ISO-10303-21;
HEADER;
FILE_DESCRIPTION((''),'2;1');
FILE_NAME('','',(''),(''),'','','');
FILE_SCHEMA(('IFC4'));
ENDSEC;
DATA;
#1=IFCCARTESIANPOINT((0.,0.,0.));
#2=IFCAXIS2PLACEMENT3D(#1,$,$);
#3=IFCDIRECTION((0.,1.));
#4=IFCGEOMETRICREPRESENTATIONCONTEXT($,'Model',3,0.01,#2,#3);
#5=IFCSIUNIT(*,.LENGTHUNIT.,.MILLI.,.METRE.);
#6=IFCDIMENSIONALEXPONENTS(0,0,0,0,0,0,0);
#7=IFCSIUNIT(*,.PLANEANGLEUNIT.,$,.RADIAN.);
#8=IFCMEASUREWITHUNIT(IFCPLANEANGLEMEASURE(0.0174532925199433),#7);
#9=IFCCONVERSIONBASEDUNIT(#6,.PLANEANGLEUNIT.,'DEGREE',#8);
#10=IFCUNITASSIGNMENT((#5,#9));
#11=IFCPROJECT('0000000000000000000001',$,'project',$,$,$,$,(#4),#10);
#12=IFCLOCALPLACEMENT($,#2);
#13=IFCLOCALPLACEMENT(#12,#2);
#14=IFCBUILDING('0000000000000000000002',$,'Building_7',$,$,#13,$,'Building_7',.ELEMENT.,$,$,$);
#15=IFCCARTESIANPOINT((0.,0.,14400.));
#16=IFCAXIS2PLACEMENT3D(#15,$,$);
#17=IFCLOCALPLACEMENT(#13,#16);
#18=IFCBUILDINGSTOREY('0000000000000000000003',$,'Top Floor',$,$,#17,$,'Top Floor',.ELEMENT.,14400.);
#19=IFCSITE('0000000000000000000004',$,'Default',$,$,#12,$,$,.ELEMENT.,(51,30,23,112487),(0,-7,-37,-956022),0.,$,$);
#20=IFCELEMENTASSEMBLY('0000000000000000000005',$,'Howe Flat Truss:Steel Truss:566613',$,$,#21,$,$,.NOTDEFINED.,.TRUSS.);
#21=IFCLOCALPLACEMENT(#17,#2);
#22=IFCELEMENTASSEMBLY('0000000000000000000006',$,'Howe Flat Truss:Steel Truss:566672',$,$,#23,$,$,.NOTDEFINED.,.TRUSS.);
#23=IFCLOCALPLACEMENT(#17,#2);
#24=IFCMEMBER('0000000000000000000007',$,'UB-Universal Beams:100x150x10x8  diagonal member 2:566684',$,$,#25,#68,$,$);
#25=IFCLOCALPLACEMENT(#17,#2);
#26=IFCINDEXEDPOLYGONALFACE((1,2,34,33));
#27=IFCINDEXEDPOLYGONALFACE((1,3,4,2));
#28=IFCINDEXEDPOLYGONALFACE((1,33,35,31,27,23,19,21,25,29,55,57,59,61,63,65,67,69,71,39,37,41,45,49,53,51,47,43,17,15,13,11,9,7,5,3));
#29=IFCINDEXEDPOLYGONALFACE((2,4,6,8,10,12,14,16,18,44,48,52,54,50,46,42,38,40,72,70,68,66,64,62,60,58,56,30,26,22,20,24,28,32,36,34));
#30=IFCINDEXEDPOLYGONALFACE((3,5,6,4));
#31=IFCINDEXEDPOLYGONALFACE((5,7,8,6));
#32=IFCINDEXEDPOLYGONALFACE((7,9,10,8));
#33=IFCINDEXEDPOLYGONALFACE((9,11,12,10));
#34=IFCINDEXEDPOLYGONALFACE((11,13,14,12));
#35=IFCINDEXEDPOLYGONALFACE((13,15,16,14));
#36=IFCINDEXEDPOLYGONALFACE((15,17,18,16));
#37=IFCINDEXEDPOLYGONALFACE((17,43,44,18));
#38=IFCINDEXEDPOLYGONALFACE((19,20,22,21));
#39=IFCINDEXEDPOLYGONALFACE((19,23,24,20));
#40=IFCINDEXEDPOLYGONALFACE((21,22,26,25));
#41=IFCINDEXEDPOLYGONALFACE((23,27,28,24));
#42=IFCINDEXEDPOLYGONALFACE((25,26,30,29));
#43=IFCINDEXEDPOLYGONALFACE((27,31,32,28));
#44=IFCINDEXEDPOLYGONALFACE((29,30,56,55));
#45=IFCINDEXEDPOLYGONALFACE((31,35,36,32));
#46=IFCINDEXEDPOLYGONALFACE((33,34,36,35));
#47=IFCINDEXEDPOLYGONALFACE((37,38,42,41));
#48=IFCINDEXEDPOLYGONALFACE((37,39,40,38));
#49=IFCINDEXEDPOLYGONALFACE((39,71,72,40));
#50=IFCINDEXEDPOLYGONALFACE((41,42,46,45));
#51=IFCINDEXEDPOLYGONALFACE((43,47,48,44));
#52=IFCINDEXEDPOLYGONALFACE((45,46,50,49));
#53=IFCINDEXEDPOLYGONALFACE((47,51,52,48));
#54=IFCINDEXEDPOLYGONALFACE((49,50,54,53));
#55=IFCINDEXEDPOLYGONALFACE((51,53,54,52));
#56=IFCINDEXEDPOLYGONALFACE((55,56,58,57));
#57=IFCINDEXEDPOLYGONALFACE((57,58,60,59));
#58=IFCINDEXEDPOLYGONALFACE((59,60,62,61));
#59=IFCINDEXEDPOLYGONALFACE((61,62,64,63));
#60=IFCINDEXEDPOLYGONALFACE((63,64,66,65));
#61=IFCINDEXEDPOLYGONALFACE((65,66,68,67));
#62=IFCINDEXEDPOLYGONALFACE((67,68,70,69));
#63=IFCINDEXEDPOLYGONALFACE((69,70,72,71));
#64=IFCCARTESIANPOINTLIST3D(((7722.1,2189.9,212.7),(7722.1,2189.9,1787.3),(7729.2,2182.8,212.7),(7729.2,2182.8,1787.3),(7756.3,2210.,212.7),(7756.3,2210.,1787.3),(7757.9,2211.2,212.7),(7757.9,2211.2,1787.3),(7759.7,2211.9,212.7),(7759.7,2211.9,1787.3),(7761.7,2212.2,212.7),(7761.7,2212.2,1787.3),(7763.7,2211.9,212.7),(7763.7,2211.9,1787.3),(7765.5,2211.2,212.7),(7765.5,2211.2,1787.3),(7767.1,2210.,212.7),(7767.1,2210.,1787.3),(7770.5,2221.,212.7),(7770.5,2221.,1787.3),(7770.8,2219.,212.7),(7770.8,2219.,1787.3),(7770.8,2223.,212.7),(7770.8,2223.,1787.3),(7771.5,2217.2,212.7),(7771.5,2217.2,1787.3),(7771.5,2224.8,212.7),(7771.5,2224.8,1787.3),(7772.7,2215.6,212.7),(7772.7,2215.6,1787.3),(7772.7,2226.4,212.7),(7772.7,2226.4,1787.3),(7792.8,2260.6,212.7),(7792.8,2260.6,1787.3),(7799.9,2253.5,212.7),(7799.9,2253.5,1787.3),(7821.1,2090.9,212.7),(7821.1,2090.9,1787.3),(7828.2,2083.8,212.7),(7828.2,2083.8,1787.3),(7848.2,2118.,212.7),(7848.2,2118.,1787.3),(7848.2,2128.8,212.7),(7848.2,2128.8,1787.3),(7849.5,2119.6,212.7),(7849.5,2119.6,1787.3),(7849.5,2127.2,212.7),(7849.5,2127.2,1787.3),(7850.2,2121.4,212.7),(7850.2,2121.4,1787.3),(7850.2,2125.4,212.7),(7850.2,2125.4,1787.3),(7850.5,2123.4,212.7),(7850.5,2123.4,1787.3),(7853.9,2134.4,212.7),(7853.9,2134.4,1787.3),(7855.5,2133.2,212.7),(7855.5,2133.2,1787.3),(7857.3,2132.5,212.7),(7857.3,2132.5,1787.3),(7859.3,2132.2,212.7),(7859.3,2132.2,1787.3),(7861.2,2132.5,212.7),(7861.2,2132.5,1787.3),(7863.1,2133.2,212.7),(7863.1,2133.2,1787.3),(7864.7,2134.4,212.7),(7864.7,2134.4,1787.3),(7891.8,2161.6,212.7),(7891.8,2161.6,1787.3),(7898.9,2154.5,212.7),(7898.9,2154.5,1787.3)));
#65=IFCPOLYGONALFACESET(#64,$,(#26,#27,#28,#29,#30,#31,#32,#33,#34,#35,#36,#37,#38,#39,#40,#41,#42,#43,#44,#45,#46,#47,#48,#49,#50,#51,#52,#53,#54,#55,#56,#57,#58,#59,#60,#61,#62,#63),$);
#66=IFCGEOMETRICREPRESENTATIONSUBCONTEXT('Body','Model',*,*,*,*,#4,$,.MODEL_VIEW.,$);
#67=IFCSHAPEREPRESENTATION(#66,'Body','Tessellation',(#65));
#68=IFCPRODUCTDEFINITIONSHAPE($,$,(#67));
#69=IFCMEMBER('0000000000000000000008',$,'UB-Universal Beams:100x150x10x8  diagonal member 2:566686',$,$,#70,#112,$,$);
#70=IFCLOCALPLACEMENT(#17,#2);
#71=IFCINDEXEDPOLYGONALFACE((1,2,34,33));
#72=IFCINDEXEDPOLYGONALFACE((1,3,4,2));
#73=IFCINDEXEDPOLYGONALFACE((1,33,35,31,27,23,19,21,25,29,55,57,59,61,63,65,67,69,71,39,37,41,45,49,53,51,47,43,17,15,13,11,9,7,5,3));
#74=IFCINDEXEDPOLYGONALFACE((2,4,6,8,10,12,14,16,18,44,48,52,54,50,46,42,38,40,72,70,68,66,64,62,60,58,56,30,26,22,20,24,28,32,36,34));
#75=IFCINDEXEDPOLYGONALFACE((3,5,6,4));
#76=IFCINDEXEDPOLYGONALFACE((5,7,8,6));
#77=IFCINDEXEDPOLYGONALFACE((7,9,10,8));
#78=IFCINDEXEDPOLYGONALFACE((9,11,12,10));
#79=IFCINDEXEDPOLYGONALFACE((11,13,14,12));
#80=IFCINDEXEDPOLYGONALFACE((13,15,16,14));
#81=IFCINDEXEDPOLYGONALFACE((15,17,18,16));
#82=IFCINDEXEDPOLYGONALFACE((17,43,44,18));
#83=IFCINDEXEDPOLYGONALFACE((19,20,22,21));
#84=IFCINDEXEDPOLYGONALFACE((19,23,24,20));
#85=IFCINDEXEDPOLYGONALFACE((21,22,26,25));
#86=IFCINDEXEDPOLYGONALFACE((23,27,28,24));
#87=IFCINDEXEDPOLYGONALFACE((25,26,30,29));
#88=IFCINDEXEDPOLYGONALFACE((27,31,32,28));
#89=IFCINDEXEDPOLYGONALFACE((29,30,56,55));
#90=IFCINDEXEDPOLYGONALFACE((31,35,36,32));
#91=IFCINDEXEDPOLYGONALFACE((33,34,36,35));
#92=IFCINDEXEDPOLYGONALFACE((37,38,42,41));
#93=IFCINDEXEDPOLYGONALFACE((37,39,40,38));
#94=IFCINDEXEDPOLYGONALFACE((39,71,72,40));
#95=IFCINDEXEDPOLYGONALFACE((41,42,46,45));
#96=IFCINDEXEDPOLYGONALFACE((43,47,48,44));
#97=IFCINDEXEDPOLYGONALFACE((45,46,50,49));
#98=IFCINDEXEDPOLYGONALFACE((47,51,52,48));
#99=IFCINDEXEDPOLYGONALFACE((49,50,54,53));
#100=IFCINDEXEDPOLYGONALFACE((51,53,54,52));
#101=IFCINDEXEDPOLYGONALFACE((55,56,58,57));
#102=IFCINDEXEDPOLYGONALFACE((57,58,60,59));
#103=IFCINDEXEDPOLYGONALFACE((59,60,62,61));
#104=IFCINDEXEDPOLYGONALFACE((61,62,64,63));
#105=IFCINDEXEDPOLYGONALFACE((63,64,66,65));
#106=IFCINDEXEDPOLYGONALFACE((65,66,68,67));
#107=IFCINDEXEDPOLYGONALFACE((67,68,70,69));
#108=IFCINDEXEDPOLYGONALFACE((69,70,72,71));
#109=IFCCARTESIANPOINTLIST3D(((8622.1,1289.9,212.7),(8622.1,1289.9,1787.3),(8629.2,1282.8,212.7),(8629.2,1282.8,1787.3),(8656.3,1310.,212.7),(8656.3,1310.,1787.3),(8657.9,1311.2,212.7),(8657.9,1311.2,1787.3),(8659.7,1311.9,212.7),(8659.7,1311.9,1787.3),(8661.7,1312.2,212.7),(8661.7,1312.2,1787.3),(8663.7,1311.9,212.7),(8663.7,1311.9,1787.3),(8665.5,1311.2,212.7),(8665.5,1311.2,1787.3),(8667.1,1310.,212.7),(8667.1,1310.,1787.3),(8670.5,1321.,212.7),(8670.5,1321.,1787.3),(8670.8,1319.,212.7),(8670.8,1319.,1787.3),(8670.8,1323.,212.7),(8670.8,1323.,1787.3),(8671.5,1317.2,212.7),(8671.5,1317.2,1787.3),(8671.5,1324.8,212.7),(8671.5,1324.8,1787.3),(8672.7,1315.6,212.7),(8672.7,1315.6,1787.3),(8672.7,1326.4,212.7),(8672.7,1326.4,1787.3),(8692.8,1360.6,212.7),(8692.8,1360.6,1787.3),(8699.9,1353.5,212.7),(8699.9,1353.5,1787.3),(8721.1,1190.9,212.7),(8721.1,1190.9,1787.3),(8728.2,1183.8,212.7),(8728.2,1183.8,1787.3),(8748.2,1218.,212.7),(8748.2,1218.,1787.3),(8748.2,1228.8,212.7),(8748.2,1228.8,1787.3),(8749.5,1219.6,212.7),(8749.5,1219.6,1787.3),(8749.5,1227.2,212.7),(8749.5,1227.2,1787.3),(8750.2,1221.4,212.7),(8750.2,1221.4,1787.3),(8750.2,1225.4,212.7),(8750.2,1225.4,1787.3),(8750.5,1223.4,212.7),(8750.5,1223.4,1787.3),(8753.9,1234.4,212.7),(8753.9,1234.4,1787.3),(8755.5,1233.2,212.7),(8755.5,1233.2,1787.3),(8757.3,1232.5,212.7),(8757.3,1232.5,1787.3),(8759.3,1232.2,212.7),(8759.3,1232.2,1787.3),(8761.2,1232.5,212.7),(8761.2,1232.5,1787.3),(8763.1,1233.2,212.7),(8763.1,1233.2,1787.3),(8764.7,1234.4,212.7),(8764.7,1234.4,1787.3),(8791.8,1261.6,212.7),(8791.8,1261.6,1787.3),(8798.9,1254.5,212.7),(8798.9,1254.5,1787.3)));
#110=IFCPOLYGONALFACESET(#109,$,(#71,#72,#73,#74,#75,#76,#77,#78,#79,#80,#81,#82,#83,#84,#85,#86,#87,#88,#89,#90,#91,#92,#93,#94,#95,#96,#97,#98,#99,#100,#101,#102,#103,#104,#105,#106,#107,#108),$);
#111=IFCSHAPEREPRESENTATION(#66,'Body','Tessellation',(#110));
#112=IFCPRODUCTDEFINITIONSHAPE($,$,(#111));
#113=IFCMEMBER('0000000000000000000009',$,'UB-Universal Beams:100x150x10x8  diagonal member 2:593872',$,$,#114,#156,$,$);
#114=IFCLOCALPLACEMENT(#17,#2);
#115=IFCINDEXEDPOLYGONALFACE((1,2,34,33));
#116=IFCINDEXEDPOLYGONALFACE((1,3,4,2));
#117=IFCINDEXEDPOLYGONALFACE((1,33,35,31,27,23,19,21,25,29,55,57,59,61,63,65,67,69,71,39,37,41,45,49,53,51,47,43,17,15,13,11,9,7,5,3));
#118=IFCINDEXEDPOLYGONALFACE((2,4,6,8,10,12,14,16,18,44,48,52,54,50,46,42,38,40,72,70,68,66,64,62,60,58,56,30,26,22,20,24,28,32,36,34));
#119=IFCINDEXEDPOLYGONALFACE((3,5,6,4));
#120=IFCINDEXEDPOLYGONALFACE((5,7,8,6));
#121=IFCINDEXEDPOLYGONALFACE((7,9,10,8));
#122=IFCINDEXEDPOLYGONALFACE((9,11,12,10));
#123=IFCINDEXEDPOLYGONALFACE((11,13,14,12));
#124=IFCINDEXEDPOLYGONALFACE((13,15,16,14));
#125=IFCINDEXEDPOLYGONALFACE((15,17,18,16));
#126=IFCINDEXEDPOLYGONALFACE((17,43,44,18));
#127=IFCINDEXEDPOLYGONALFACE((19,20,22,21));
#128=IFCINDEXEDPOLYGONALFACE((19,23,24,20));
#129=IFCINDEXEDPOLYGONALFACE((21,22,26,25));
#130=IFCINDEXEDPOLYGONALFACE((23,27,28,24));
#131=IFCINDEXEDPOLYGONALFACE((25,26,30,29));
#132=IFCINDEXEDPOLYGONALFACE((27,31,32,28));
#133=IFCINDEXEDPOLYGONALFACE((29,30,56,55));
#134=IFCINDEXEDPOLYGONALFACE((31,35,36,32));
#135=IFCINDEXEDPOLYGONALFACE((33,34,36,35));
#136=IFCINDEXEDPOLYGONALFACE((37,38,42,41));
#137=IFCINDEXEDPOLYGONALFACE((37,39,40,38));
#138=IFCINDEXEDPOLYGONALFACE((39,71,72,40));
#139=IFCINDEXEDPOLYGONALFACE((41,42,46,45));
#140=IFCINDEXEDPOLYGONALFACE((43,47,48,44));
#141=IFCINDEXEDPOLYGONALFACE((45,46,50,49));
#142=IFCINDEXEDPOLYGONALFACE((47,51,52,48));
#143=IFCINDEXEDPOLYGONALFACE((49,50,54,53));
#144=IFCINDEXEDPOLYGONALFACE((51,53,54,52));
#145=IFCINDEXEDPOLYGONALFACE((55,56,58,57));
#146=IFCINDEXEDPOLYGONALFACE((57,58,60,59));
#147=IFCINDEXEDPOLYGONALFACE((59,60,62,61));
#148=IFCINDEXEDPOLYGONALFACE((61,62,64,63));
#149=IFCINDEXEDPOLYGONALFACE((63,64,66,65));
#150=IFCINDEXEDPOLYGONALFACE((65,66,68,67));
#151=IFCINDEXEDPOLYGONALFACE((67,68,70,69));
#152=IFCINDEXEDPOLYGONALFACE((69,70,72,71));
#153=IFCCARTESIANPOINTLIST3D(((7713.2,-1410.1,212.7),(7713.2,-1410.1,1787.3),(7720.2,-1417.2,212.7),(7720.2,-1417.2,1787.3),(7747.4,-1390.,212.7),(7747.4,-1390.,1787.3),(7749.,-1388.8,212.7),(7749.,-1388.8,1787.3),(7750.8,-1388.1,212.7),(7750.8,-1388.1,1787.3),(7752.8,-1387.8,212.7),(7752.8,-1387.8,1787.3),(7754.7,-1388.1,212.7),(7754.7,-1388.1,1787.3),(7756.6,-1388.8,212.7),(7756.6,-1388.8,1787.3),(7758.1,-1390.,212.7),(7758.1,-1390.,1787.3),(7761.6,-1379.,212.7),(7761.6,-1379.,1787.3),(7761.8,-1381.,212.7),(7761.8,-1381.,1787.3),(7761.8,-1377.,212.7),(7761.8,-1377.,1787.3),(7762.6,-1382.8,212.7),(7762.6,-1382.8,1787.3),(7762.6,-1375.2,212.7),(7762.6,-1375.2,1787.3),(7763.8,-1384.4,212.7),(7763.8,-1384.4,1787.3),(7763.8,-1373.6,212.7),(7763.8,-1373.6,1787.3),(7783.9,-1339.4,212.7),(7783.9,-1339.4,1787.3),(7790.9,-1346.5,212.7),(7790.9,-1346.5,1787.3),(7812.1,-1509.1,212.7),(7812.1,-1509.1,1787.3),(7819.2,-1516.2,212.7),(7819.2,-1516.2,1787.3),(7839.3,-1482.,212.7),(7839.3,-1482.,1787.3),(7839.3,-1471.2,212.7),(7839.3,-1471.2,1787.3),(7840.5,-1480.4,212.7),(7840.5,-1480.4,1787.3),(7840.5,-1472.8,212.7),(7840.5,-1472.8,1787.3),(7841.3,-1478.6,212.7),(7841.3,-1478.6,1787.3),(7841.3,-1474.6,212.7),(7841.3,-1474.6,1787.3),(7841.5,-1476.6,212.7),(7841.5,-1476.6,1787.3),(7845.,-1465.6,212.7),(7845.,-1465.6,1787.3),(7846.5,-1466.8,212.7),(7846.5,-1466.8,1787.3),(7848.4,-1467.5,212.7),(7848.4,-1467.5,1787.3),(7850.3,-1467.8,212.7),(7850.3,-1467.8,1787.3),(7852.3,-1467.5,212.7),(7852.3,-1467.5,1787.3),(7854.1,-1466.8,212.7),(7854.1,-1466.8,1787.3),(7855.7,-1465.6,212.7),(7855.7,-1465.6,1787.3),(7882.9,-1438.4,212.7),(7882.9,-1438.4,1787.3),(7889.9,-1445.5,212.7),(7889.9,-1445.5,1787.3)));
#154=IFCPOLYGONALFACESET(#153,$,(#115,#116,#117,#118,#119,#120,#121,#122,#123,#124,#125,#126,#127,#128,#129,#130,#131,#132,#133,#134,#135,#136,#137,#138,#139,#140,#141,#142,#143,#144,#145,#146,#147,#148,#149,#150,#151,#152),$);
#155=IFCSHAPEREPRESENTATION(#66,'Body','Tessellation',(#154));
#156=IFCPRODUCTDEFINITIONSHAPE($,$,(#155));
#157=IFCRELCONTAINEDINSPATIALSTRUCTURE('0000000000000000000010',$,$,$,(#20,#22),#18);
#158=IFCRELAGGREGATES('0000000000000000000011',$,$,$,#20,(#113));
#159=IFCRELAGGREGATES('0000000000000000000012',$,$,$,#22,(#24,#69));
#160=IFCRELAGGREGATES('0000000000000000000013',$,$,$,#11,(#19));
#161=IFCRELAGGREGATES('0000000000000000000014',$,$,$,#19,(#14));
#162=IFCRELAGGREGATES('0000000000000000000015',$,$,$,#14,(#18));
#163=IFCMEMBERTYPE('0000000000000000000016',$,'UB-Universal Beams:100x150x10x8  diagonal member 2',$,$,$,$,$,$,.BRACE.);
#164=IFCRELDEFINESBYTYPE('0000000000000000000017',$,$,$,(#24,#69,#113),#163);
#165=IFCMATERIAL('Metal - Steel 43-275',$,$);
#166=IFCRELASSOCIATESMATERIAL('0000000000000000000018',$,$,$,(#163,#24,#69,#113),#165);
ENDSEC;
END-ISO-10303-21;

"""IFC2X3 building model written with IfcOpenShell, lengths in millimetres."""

from ifc_helpers import new_model, entity, si_unit, converted_unit, direction, frame, frame_2d, origin, place, context, subcontext, project, spatial, polyline, circle_curve, parameter, trimmed, segment, composite_curve, outline, extrude, source, transform, mapped, material, type_object, type_shapes, element, aggregate, save


model = new_model("IFC2X3")

# Units and contexts
model_context = context("Model", 3, precision=0.01, world=origin(), true_north=direction((0.0, 1.0)))
body_context = subcontext(model_context, "Body", "Model", "MODEL_VIEW")
ifc_project = project(units=[si_unit("LENGTHUNIT", "METRE", prefix="MILLI"), converted_unit("PLANEANGLEUNIT", "DEGREE", entity("IfcPlaneAngleMeasure", 0.0174532925199433), si_unit("PLANEANGLEUNIT", "RADIAN"), dimensions=[0, 0, 0, 0, 0, 0, 0])], contexts=[model_context])

# Site, building, storey
site_placement = place(None, origin())
site = spatial("IfcSite", under=ifc_project, at=site_placement, Name="Default", CompositionType="ELEMENT", RefLatitude=(51, 30, 23, 112487), RefLongitude=(0, -7, -37, -956022), RefElevation=0.0)
building_placement = place(site_placement, origin())
building = spatial("IfcBuilding", under=site, at=building_placement, Name="Building_7", LongName="Building_7", CompositionType="ELEMENT")
storey_placement = place(building_placement, frame((0.0, 0.0, 14400.0)))
storey = spatial("IfcBuildingStorey", under=building, at=storey_placement, Name="Top Floor", LongName="Top Floor", CompositionType="ELEMENT", Elevation=14400.0)

# Shared definitions
ifc_material = material(Name="Metal - Steel 43-275")

# Shared definitions
member_type_1 = type_object("IfcMemberType", Name="UB-Universal Beams:100x150x10x8  diagonal member 2", PredefinedType="BRACE", material=ifc_material)
shared_shape_1 = source(origin(), body_context, "Body", "SweptSolid", [
    extrude(outline(composite_curve([segment(polyline([(-50.0, -65.0), (-50.0, -75.0)]), True, "CONTINUOUS"), segment(polyline([(-50.0, -75.0), (50.0, -75.0)]), True, "CONTINUOUS"), segment(polyline([(50.0, -75.0), (50.0, -65.0)]), True, "CONTINUOUS"), segment(polyline([(50.0, -65.0), (11.6, -65.0)]), True, "CONTINUOUS"), segment(trimmed(circle_curve(frame_2d((11.6, -57.4), x_axis=(1.0, 0.0)), 7.6), [parameter(180.0)], [parameter(270.0)], True, "PARAMETER"), False, "CONTINUOUS"), segment(polyline([(4.0, -57.4), (4.0, 57.4)]), True, "CONTINUOUS"), segment(trimmed(circle_curve(frame_2d((11.6, 57.4), x_axis=(1.0, 0.0)), 7.6), [parameter(90.0)], [parameter(180.0)], True, "PARAMETER"), False, "CONTINUOUS"), segment(polyline([(11.6, 65.0), (50.0, 65.0)]), True, "CONTINUOUS"), segment(polyline([(50.0, 65.0), (50.0, 75.0)]), True, "CONTINUOUS"), segment(polyline([(50.0, 75.0), (-50.0, 75.0)]), True, "CONTINUOUS"), segment(polyline([(-50.0, 75.0), (-50.0, 65.0)]), True, "CONTINUOUS"), segment(polyline([(-50.0, 65.0), (-11.6, 65.0)]), True, "CONTINUOUS"), segment(trimmed(circle_curve(frame_2d((-11.6, 57.4), x_axis=(1.0, 0.0)), 7.6), [parameter(360.0)], [parameter(90.0)], True, "PARAMETER"), False, "CONTINUOUS"), segment(polyline([(-4.0, 57.4), (-4.0, -57.4)]), True, "CONTINUOUS"), segment(trimmed(circle_curve(frame_2d((-11.6, -57.4), x_axis=(1.0, 0.0)), 7.6), [parameter(270.0)], [parameter(360.0)], True, "PARAMETER"), False, "CONTINUOUS"), segment(polyline([(-11.6, -65.0), (-50.0, -65.0)]), True, "CONTINUOUS")], self_intersect=False)), frame((-787.3, 0.0, 0.0), z_axis=(-1.0, 0.0, 0.0), x_axis=(0.0, -1.0, 0.0)), (0.0, 0.0, -1.0), 1574.6),
])
type_shapes(member_type_1, [shared_shape_1])

# Element assemblies, members
assembly_1_placement = place(storey_placement, origin())
assembly_1 = element("IfcElementAssembly", 1, at=assembly_1_placement, inside=storey, Name="Howe Flat Truss:Steel Truss:566613", AssemblyPlace="NOTDEFINED", PredefinedType="TRUSS")
assembly_2_placement = place(storey_placement, origin())
assembly_2 = element("IfcElementAssembly", 2, at=assembly_2_placement, inside=storey, Name="Howe Flat Truss:Steel Truss:566672", AssemblyPlace="NOTDEFINED", PredefinedType="TRUSS")
member_1_placement = place(assembly_2_placement, frame((7810.5, 2172.2, 1000.0), z_axis=(-0.707107, 0.707107, 0.0), x_axis=(0.0, 0.0, 1.0)))
member_1 = element("IfcMember", 3, at=member_1_placement, type_object=member_type_1, material=ifc_material, Name="UB-Universal Beams:100x150x10x8  diagonal member 2:566684", context=body_context, shape_type="MappedRepresentation", body=[
    mapped(shared_shape_1, transform((0.0, 0.0, 0.0), scale=1.0)),
])
member_2_placement = place(assembly_2_placement, frame((8710.5, 1272.2, 1000.0), z_axis=(-0.707107, 0.707107, 0.0), x_axis=(0.0, 0.0, 1.0)))
member_2 = element("IfcMember", 4, at=member_2_placement, type_object=member_type_1, material=ifc_material, Name="UB-Universal Beams:100x150x10x8  diagonal member 2:566686", context=body_context, shape_type="MappedRepresentation", body=[
    mapped(shared_shape_1, transform((0.0, 0.0, 0.0), scale=1.0)),
])

# Member
member_3_placement = place(assembly_1_placement, frame((7801.5, -1427.8, 1000.0), z_axis=(0.707107, -0.707107, 0.0), x_axis=(0.0, 0.0, 1.0)))
member_3 = element("IfcMember", 5, at=member_3_placement, type_object=member_type_1, material=ifc_material, Name="UB-Universal Beams:100x150x10x8  diagonal member 2:593872", context=body_context, shape_type="MappedRepresentation", body=[
    mapped(shared_shape_1, transform((0.0, 0.0, 0.0), scale=1.0)),
])
aggregate(assembly_1, [member_3])
aggregate(assembly_2, [member_1, member_2])

save(model, "model.ifc")
